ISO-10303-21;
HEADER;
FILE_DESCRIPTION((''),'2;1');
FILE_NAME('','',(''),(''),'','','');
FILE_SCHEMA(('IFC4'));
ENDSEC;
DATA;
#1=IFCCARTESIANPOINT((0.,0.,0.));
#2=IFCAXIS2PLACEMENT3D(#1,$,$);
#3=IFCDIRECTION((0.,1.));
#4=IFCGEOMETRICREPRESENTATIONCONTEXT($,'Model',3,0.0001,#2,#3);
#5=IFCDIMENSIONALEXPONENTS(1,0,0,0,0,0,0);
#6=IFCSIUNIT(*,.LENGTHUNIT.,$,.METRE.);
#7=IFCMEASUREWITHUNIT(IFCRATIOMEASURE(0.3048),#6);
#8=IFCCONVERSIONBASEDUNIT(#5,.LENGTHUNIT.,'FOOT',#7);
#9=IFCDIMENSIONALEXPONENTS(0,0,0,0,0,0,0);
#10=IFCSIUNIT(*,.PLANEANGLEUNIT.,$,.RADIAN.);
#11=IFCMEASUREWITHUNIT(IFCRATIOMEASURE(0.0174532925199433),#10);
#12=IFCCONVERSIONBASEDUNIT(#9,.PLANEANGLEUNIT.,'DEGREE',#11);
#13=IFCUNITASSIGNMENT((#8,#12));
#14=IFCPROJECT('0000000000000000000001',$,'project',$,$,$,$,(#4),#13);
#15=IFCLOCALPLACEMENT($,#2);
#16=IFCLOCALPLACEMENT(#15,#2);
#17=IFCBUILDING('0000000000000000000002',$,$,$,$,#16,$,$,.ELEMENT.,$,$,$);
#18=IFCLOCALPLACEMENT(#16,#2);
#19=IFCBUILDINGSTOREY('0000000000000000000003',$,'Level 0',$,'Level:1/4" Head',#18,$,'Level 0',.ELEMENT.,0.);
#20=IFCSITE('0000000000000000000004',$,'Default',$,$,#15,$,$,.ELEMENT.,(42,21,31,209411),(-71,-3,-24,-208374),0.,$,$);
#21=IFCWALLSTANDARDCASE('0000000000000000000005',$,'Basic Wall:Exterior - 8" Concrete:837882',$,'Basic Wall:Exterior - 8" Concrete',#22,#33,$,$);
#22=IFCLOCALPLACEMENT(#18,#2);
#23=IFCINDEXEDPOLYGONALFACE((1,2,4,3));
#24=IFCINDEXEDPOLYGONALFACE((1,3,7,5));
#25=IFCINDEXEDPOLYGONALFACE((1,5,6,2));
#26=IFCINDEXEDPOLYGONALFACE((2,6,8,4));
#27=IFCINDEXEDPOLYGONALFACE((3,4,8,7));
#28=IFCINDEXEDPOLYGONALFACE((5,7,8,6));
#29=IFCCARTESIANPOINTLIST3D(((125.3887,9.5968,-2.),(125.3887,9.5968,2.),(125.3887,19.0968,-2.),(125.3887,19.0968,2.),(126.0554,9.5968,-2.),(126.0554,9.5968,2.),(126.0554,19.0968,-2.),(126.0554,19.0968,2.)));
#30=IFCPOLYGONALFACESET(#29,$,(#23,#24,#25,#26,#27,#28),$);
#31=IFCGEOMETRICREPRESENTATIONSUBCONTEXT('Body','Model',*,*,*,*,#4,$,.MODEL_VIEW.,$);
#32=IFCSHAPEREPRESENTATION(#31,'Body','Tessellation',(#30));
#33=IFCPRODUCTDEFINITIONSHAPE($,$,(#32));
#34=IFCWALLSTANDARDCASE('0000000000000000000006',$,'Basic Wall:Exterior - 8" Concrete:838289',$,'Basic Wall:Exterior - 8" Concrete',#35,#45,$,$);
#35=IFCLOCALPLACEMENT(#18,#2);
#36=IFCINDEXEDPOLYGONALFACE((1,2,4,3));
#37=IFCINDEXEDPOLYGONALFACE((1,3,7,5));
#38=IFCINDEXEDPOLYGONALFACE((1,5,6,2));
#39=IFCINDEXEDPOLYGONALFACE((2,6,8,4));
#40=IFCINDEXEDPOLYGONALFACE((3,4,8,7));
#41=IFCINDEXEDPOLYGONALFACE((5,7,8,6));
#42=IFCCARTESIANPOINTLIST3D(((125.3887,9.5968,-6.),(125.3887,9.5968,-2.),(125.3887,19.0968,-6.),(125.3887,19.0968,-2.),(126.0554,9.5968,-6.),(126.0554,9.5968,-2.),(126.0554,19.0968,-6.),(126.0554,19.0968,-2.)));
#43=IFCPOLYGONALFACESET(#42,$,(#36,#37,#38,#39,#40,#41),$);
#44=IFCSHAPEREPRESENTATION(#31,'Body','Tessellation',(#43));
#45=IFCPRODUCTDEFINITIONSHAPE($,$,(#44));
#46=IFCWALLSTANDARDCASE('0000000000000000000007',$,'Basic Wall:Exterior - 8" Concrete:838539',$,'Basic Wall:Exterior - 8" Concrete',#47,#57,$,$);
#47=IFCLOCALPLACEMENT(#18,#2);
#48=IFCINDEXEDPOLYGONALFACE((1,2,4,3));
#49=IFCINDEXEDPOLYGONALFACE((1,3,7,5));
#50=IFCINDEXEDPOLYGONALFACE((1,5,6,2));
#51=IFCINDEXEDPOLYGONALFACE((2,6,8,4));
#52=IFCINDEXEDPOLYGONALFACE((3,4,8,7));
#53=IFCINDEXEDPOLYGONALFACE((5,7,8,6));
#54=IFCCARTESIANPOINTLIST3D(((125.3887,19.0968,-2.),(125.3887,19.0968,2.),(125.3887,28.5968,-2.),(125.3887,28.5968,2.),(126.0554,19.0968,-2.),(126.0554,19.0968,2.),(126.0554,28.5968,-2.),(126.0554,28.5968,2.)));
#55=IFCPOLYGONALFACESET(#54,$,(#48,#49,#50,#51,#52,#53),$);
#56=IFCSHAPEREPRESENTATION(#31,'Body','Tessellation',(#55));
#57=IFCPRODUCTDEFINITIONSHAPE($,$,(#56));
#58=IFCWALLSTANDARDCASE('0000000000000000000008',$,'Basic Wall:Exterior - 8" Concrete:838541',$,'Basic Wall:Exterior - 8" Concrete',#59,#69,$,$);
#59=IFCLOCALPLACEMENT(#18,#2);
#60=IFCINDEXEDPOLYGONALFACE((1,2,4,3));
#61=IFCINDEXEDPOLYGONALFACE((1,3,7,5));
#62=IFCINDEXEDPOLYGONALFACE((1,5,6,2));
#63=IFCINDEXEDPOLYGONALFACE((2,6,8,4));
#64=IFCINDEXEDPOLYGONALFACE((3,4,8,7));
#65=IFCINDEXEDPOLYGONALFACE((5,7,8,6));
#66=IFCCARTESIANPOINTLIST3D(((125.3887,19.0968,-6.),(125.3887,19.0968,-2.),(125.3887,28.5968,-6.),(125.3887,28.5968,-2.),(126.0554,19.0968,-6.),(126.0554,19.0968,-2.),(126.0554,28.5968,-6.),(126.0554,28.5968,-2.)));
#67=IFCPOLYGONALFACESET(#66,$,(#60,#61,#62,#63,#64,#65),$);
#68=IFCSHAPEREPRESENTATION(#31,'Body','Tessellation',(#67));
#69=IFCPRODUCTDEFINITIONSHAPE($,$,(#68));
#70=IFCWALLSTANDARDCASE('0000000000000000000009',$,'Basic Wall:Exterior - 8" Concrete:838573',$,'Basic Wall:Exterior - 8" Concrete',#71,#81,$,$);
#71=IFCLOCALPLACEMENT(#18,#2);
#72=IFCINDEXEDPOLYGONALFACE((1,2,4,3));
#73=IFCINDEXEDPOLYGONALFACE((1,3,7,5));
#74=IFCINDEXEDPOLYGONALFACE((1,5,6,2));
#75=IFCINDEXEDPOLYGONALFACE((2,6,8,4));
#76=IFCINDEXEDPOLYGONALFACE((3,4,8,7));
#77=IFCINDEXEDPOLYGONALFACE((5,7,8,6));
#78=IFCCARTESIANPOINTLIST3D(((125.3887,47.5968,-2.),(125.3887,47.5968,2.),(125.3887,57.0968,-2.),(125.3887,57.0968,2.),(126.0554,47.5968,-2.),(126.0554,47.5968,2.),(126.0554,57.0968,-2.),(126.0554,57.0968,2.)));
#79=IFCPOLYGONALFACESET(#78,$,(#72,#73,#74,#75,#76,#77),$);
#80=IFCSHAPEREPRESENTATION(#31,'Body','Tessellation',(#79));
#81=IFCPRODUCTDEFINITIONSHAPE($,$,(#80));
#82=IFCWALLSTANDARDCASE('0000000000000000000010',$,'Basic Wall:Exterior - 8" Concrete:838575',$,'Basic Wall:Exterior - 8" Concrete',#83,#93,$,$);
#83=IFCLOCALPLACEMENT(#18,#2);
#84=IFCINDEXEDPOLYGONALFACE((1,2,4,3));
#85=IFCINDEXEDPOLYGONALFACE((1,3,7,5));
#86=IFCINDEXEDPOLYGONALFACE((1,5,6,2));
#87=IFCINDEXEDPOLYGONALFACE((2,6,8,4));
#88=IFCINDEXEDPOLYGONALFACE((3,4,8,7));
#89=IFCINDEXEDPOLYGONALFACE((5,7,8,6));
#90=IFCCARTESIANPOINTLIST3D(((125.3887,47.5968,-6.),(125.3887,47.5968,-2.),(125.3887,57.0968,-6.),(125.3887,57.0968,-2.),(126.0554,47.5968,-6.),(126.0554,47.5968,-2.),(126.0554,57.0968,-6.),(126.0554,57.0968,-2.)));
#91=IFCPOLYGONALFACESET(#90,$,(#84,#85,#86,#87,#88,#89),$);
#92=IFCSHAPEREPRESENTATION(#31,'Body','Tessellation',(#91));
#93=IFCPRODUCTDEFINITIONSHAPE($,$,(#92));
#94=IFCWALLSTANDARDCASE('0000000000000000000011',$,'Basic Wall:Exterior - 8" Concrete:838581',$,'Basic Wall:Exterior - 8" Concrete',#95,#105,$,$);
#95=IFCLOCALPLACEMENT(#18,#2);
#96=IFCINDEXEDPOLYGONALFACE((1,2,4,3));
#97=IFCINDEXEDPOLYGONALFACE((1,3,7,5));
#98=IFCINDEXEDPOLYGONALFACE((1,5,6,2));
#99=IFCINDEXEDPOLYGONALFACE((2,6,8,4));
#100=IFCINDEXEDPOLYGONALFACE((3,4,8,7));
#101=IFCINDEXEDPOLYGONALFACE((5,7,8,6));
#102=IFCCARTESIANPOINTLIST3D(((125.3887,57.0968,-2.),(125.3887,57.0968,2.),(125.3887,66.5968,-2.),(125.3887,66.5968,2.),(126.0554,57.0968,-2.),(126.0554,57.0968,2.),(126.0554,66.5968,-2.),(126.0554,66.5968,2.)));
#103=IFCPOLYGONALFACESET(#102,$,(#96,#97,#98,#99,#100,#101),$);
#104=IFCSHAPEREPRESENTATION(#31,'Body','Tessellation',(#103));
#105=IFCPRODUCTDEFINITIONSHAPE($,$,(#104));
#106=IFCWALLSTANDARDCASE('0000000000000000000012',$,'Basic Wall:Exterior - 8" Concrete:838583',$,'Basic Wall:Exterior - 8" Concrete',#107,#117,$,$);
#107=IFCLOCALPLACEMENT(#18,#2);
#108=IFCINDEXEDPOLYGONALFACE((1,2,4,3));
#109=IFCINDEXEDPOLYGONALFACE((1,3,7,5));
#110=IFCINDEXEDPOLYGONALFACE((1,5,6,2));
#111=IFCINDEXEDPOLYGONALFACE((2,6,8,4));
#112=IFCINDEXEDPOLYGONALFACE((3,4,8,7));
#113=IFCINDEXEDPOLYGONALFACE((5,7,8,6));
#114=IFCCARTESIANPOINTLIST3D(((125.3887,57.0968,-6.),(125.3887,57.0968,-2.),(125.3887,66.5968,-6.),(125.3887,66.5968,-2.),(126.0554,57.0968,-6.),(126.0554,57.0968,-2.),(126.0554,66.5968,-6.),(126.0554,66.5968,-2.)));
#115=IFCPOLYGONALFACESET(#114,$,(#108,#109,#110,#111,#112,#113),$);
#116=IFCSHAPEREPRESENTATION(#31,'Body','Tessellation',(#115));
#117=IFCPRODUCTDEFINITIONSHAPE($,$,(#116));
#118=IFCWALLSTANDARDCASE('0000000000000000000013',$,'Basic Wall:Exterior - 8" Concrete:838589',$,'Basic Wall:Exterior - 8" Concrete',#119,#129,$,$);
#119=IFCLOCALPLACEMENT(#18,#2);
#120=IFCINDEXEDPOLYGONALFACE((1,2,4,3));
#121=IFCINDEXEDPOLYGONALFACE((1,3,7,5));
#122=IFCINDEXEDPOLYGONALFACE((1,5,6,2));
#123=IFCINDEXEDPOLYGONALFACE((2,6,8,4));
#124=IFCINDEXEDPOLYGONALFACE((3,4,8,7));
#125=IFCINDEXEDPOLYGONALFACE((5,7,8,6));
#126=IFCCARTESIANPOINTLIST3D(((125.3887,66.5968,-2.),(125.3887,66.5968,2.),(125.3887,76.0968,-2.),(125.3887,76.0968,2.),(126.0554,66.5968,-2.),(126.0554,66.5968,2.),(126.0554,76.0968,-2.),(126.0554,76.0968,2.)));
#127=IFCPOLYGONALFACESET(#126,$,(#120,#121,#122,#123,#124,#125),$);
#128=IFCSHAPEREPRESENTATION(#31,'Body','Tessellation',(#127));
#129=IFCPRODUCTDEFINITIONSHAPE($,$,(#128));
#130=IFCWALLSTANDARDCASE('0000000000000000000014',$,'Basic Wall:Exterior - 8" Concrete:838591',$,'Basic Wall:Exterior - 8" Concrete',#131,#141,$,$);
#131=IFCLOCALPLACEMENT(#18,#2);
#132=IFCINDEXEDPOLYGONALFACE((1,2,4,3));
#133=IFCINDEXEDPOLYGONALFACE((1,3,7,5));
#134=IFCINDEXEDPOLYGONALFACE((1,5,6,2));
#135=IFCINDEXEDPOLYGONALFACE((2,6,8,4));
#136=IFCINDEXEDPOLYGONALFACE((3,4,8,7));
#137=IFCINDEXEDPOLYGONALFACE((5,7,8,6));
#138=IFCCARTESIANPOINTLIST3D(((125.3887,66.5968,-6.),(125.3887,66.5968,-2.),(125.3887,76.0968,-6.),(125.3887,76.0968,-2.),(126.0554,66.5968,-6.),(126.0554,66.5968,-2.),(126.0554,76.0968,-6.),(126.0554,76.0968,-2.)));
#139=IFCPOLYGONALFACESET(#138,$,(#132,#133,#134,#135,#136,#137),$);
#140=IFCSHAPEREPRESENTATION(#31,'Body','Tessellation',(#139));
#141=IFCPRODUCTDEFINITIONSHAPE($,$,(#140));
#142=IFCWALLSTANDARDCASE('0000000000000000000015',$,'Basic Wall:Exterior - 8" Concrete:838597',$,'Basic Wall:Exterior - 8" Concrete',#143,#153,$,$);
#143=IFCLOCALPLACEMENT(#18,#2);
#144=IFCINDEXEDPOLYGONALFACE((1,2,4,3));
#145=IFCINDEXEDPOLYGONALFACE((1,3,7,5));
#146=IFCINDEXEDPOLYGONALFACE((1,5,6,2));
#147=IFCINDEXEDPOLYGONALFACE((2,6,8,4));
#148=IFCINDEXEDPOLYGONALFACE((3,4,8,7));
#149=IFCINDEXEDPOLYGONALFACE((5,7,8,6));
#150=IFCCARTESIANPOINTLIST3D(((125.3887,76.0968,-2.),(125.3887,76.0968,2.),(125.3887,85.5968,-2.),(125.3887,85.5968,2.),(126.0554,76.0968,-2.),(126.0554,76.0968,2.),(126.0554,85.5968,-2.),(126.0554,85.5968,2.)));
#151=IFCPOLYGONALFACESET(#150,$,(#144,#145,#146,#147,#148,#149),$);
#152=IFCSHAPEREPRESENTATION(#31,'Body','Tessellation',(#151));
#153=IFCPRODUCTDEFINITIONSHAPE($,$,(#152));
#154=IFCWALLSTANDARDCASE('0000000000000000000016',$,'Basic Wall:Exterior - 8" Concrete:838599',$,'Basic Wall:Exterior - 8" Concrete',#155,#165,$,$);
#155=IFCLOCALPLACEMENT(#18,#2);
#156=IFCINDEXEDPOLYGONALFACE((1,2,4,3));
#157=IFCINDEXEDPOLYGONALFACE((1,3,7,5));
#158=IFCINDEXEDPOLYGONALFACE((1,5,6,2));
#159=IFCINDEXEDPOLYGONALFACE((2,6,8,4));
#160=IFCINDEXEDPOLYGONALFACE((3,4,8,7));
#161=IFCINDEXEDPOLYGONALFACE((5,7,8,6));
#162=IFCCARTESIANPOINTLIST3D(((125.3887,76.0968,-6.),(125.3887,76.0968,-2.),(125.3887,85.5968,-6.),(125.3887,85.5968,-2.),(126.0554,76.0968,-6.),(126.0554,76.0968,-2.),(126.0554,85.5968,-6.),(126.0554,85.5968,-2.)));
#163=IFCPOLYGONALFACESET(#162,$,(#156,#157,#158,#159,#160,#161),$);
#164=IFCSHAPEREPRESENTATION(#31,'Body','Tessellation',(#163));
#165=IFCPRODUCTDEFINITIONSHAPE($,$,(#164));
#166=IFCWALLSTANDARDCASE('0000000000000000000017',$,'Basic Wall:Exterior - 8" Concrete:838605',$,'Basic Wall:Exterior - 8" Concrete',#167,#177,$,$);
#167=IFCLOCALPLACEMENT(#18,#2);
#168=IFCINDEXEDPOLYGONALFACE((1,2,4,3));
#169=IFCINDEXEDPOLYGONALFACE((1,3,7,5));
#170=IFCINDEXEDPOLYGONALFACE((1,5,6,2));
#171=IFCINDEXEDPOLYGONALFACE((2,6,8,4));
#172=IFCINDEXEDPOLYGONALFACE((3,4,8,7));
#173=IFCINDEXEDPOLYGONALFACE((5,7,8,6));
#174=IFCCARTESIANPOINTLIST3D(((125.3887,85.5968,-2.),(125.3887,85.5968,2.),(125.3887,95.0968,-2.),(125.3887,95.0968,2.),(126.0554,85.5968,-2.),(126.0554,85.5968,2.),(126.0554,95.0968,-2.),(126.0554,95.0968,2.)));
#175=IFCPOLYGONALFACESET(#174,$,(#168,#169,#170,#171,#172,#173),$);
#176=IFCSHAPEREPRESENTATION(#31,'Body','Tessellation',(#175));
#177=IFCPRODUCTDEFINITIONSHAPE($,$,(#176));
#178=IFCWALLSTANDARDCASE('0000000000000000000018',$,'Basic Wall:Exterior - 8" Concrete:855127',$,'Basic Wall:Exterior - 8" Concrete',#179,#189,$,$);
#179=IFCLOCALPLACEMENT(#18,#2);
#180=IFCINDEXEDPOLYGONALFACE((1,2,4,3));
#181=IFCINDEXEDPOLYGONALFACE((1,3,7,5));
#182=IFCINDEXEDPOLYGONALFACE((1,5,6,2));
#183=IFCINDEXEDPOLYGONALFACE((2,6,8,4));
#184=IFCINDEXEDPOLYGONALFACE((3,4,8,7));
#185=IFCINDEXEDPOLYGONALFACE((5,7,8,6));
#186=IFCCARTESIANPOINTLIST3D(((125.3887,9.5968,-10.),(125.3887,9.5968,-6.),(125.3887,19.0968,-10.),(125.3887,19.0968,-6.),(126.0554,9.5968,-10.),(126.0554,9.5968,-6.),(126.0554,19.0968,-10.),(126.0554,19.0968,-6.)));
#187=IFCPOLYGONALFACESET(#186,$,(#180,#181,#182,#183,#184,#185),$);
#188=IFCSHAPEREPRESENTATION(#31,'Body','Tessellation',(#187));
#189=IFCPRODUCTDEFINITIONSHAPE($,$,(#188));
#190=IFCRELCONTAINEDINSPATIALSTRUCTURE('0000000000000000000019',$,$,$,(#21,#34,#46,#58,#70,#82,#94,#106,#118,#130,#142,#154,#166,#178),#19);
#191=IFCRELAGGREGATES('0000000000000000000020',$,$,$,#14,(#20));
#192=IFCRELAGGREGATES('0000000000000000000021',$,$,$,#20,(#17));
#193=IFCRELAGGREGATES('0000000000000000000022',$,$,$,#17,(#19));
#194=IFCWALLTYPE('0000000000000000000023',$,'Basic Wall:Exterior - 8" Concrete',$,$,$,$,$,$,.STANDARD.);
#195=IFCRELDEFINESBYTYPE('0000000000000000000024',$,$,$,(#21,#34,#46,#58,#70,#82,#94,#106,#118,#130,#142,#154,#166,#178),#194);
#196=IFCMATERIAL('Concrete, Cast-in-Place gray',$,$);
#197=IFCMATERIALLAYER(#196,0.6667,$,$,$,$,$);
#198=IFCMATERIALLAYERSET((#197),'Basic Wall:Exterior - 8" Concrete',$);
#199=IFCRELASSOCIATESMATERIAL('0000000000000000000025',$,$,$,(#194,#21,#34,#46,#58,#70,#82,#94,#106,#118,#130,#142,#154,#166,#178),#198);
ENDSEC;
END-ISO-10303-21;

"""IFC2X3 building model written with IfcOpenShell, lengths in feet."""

from ifc_helpers import new_model, entity, si_unit, converted_unit, direction, frame, frame_2d, origin, place, context, subcontext, project, spatial, rectangle, extrude, material, layer, layer_set, layer_usage, type_object, element, save


model = new_model("IFC2X3")

# Units and contexts
model_context = context("Model", 3, precision=0.0001, world=origin(), true_north=direction((0.0, 1.0)))
body_context = subcontext(model_context, "Body", "Model", "MODEL_VIEW")
ifc_project = project(units=[converted_unit("LENGTHUNIT", "FOOT", entity("IfcRatioMeasure", 0.3048), si_unit("LENGTHUNIT", "METRE"), dimensions=[1, 0, 0, 0, 0, 0, 0]), converted_unit("PLANEANGLEUNIT", "DEGREE", entity("IfcRatioMeasure", 0.0174532925199433), si_unit("PLANEANGLEUNIT", "RADIAN"), dimensions=[0, 0, 0, 0, 0, 0, 0])], contexts=[model_context])

# Site, building, storey
site_placement = place(None, origin())
site = spatial("IfcSite", under=ifc_project, at=site_placement, Name="Default", CompositionType="ELEMENT", RefLatitude=(42, 21, 31, 209411), RefLongitude=(-71, -3, -24, -208374), RefElevation=0.0)
building_placement = place(site_placement, origin())
building = spatial("IfcBuilding", under=site, at=building_placement, CompositionType="ELEMENT")
storey_placement = place(building_placement, origin())
storey = spatial("IfcBuildingStorey", under=building, at=storey_placement, Name="Level 0", ObjectType="Level:1/4\" Head", LongName="Level 0", CompositionType="ELEMENT", Elevation=0.0)

# Walls
ifc_material_1 = material(Name="Concrete, Cast-in-Place gray")
ifc_layer = layer(ifc_material_1, 0.6667)
ifc_layer_set = layer_set([ifc_layer], Name="Basic Wall:Exterior - 8\" Concrete")
ifc_layer_usage_1 = layer_usage(ifc_layer_set, "AXIS2", "NEGATIVE", 0.3333)
wall_type = type_object("IfcWallType", Name="Basic Wall:Exterior - 8\" Concrete", PredefinedType="STANDARD", material=ifc_layer_set)
wall_1_placement = place(storey_placement, frame((125.722, 9.5968, -2.0), z_axis=(0.0, 0.0, 1.0), x_axis=(0.0, 1.0, 0.0)))
element("IfcWallStandardCase", 1, at=wall_1_placement, inside=storey, type_object=wall_type, material=ifc_layer_usage_1, Name="Basic Wall:Exterior - 8\" Concrete:837882", ObjectType="Basic Wall:Exterior - 8\" Concrete", context=body_context, shape_type="SweptSolid", body=[
    extrude(rectangle(XDim=9.5, YDim=0.6667, at=frame_2d((4.75, 0.0), x_axis=(-1.0, 0.0))), origin(), (0.0, 0.0, 1.0), 4.0),
])
ifc_layer_usage_2 = layer_usage(ifc_layer_set, "AXIS2", "NEGATIVE", 0.3333)
wall_2_placement = place(storey_placement, frame((125.722, 9.5968, -6.0), z_axis=(0.0, 0.0, 1.0), x_axis=(0.0, 1.0, 0.0)))
element("IfcWallStandardCase", 2, at=wall_2_placement, inside=storey, type_object=wall_type, material=ifc_layer_usage_2, Name="Basic Wall:Exterior - 8\" Concrete:838289", ObjectType="Basic Wall:Exterior - 8\" Concrete", context=body_context, shape_type="SweptSolid", body=[
    extrude(rectangle(XDim=9.5, YDim=0.6667, at=frame_2d((4.75, 0.0), x_axis=(-1.0, 0.0))), origin(), (0.0, 0.0, 1.0), 4.0),
])
ifc_layer_usage_3 = layer_usage(ifc_layer_set, "AXIS2", "NEGATIVE", 0.3333)
wall_3_placement = place(storey_placement, frame((125.722, 19.0968, -2.0), z_axis=(0.0, 0.0, 1.0), x_axis=(0.0, 1.0, 0.0)))
element("IfcWallStandardCase", 3, at=wall_3_placement, inside=storey, type_object=wall_type, material=ifc_layer_usage_3, Name="Basic Wall:Exterior - 8\" Concrete:838539", ObjectType="Basic Wall:Exterior - 8\" Concrete", context=body_context, shape_type="SweptSolid", body=[
    extrude(rectangle(XDim=9.5, YDim=0.6667, at=frame_2d((4.75, 0.0), x_axis=(-1.0, 0.0))), origin(), (0.0, 0.0, 1.0), 4.0),
])
ifc_layer_usage_4 = layer_usage(ifc_layer_set, "AXIS2", "NEGATIVE", 0.3333)
wall_4_placement = place(storey_placement, frame((125.722, 19.0968, -6.0), z_axis=(0.0, 0.0, 1.0), x_axis=(0.0, 1.0, 0.0)))
element("IfcWallStandardCase", 4, at=wall_4_placement, inside=storey, type_object=wall_type, material=ifc_layer_usage_4, Name="Basic Wall:Exterior - 8\" Concrete:838541", ObjectType="Basic Wall:Exterior - 8\" Concrete", context=body_context, shape_type="SweptSolid", body=[
    extrude(rectangle(XDim=9.5, YDim=0.6667, at=frame_2d((4.75, 0.0), x_axis=(-1.0, 0.0))), origin(), (0.0, 0.0, 1.0), 4.0),
])
ifc_layer_usage_5 = layer_usage(ifc_layer_set, "AXIS2", "NEGATIVE", 0.3333)
wall_5_placement = place(storey_placement, frame((125.722, 47.5968, -2.0), z_axis=(0.0, 0.0, 1.0), x_axis=(0.0, 1.0, 0.0)))
element("IfcWallStandardCase", 5, at=wall_5_placement, inside=storey, type_object=wall_type, material=ifc_layer_usage_5, Name="Basic Wall:Exterior - 8\" Concrete:838573", ObjectType="Basic Wall:Exterior - 8\" Concrete", context=body_context, shape_type="SweptSolid", body=[
    extrude(rectangle(XDim=9.5, YDim=0.6667, at=frame_2d((4.75, 0.0), x_axis=(-1.0, 0.0))), origin(), (0.0, 0.0, 1.0), 4.0),
])
ifc_layer_usage_6 = layer_usage(ifc_layer_set, "AXIS2", "NEGATIVE", 0.3333)
wall_6_placement = place(storey_placement, frame((125.722, 47.5968, -6.0), z_axis=(0.0, 0.0, 1.0), x_axis=(0.0, 1.0, 0.0)))
element("IfcWallStandardCase", 6, at=wall_6_placement, inside=storey, type_object=wall_type, material=ifc_layer_usage_6, Name="Basic Wall:Exterior - 8\" Concrete:838575", ObjectType="Basic Wall:Exterior - 8\" Concrete", context=body_context, shape_type="SweptSolid", body=[
    extrude(rectangle(XDim=9.5, YDim=0.6667, at=frame_2d((4.75, 0.0), x_axis=(-1.0, 0.0))), origin(), (0.0, 0.0, 1.0), 4.0),
])
ifc_layer_usage_7 = layer_usage(ifc_layer_set, "AXIS2", "NEGATIVE", 0.3333)
wall_7_placement = place(storey_placement, frame((125.722, 57.0968, -2.0), z_axis=(0.0, 0.0, 1.0), x_axis=(0.0, 1.0, 0.0)))
element("IfcWallStandardCase", 7, at=wall_7_placement, inside=storey, type_object=wall_type, material=ifc_layer_usage_7, Name="Basic Wall:Exterior - 8\" Concrete:838581", ObjectType="Basic Wall:Exterior - 8\" Concrete", context=body_context, shape_type="SweptSolid", body=[
    extrude(rectangle(XDim=9.5, YDim=0.6667, at=frame_2d((4.75, 0.0), x_axis=(-1.0, 0.0))), origin(), (0.0, 0.0, 1.0), 4.0),
])
ifc_layer_usage_8 = layer_usage(ifc_layer_set, "AXIS2", "NEGATIVE", 0.3333)
wall_8_placement = place(storey_placement, frame((125.722, 57.0968, -6.0), z_axis=(0.0, 0.0, 1.0), x_axis=(0.0, 1.0, 0.0)))
element("IfcWallStandardCase", 8, at=wall_8_placement, inside=storey, type_object=wall_type, material=ifc_layer_usage_8, Name="Basic Wall:Exterior - 8\" Concrete:838583", ObjectType="Basic Wall:Exterior - 8\" Concrete", context=body_context, shape_type="SweptSolid", body=[
    extrude(rectangle(XDim=9.5, YDim=0.6667, at=frame_2d((4.75, 0.0), x_axis=(-1.0, 0.0))), origin(), (0.0, 0.0, 1.0), 4.0),
])
ifc_layer_usage_9 = layer_usage(ifc_layer_set, "AXIS2", "NEGATIVE", 0.3333)
wall_9_placement = place(storey_placement, frame((125.722, 66.5968, -2.0), z_axis=(0.0, 0.0, 1.0), x_axis=(0.0, 1.0, 0.0)))
element("IfcWallStandardCase", 9, at=wall_9_placement, inside=storey, type_object=wall_type, material=ifc_layer_usage_9, Name="Basic Wall:Exterior - 8\" Concrete:838589", ObjectType="Basic Wall:Exterior - 8\" Concrete", context=body_context, shape_type="SweptSolid", body=[
    extrude(rectangle(XDim=9.5, YDim=0.6667, at=frame_2d((4.75, 0.0), x_axis=(-1.0, 0.0))), origin(), (0.0, 0.0, 1.0), 4.0),
])
ifc_layer_usage_10 = layer_usage(ifc_layer_set, "AXIS2", "NEGATIVE", 0.3333)
wall_10_placement = place(storey_placement, frame((125.722, 66.5968, -6.0), z_axis=(0.0, 0.0, 1.0), x_axis=(0.0, 1.0, 0.0)))
element("IfcWallStandardCase", 10, at=wall_10_placement, inside=storey, type_object=wall_type, material=ifc_layer_usage_10, Name="Basic Wall:Exterior - 8\" Concrete:838591", ObjectType="Basic Wall:Exterior - 8\" Concrete", context=body_context, shape_type="SweptSolid", body=[
    extrude(rectangle(XDim=9.5, YDim=0.6667, at=frame_2d((4.75, 0.0), x_axis=(-1.0, 0.0))), origin(), (0.0, 0.0, 1.0), 4.0),
])
ifc_layer_usage_11 = layer_usage(ifc_layer_set, "AXIS2", "NEGATIVE", 0.3333)
wall_11_placement = place(storey_placement, frame((125.722, 76.0968, -2.0), z_axis=(0.0, 0.0, 1.0), x_axis=(0.0, 1.0, 0.0)))
element("IfcWallStandardCase", 11, at=wall_11_placement, inside=storey, type_object=wall_type, material=ifc_layer_usage_11, Name="Basic Wall:Exterior - 8\" Concrete:838597", ObjectType="Basic Wall:Exterior - 8\" Concrete", context=body_context, shape_type="SweptSolid", body=[
    extrude(rectangle(XDim=9.5, YDim=0.6667, at=frame_2d((4.75, 0.0), x_axis=(-1.0, 0.0))), origin(), (0.0, 0.0, 1.0), 4.0),
])
ifc_layer_usage_12 = layer_usage(ifc_layer_set, "AXIS2", "NEGATIVE", 0.3333)
wall_12_placement = place(storey_placement, frame((125.722, 76.0968, -6.0), z_axis=(0.0, 0.0, 1.0), x_axis=(0.0, 1.0, 0.0)))
element("IfcWallStandardCase", 12, at=wall_12_placement, inside=storey, type_object=wall_type, material=ifc_layer_usage_12, Name="Basic Wall:Exterior - 8\" Concrete:838599", ObjectType="Basic Wall:Exterior - 8\" Concrete", context=body_context, shape_type="SweptSolid", body=[
    extrude(rectangle(XDim=9.5, YDim=0.6667, at=frame_2d((4.75, 0.0), x_axis=(-1.0, 0.0))), origin(), (0.0, 0.0, 1.0), 4.0),
])
ifc_layer_usage_13 = layer_usage(ifc_layer_set, "AXIS2", "NEGATIVE", 0.3333)
wall_13_placement = place(storey_placement, frame((125.722, 85.5968, -2.0), z_axis=(0.0, 0.0, 1.0), x_axis=(0.0, 1.0, 0.0)))
element("IfcWallStandardCase", 13, at=wall_13_placement, inside=storey, type_object=wall_type, material=ifc_layer_usage_13, Name="Basic Wall:Exterior - 8\" Concrete:838605", ObjectType="Basic Wall:Exterior - 8\" Concrete", context=body_context, shape_type="SweptSolid", body=[
    extrude(rectangle(XDim=9.5, YDim=0.6667, at=frame_2d((4.75, 0.0), x_axis=(-1.0, 0.0))), origin(), (0.0, 0.0, 1.0), 4.0),
])
ifc_layer_usage_14 = layer_usage(ifc_layer_set, "AXIS2", "NEGATIVE", 0.3333)
wall_14_placement = place(storey_placement, frame((125.722, 9.5968, -10.0), z_axis=(0.0, 0.0, 1.0), x_axis=(0.0, 1.0, 0.0)))
element("IfcWallStandardCase", 14, at=wall_14_placement, inside=storey, type_object=wall_type, material=ifc_layer_usage_14, Name="Basic Wall:Exterior - 8\" Concrete:855127", ObjectType="Basic Wall:Exterior - 8\" Concrete", context=body_context, shape_type="SweptSolid", body=[
    extrude(rectangle(XDim=9.5, YDim=0.6667, at=frame_2d((4.75, 0.0), x_axis=(-1.0, 0.0))), origin(), (0.0, 0.0, 1.0), 4.0),
])

save(model, "model.ifc")
